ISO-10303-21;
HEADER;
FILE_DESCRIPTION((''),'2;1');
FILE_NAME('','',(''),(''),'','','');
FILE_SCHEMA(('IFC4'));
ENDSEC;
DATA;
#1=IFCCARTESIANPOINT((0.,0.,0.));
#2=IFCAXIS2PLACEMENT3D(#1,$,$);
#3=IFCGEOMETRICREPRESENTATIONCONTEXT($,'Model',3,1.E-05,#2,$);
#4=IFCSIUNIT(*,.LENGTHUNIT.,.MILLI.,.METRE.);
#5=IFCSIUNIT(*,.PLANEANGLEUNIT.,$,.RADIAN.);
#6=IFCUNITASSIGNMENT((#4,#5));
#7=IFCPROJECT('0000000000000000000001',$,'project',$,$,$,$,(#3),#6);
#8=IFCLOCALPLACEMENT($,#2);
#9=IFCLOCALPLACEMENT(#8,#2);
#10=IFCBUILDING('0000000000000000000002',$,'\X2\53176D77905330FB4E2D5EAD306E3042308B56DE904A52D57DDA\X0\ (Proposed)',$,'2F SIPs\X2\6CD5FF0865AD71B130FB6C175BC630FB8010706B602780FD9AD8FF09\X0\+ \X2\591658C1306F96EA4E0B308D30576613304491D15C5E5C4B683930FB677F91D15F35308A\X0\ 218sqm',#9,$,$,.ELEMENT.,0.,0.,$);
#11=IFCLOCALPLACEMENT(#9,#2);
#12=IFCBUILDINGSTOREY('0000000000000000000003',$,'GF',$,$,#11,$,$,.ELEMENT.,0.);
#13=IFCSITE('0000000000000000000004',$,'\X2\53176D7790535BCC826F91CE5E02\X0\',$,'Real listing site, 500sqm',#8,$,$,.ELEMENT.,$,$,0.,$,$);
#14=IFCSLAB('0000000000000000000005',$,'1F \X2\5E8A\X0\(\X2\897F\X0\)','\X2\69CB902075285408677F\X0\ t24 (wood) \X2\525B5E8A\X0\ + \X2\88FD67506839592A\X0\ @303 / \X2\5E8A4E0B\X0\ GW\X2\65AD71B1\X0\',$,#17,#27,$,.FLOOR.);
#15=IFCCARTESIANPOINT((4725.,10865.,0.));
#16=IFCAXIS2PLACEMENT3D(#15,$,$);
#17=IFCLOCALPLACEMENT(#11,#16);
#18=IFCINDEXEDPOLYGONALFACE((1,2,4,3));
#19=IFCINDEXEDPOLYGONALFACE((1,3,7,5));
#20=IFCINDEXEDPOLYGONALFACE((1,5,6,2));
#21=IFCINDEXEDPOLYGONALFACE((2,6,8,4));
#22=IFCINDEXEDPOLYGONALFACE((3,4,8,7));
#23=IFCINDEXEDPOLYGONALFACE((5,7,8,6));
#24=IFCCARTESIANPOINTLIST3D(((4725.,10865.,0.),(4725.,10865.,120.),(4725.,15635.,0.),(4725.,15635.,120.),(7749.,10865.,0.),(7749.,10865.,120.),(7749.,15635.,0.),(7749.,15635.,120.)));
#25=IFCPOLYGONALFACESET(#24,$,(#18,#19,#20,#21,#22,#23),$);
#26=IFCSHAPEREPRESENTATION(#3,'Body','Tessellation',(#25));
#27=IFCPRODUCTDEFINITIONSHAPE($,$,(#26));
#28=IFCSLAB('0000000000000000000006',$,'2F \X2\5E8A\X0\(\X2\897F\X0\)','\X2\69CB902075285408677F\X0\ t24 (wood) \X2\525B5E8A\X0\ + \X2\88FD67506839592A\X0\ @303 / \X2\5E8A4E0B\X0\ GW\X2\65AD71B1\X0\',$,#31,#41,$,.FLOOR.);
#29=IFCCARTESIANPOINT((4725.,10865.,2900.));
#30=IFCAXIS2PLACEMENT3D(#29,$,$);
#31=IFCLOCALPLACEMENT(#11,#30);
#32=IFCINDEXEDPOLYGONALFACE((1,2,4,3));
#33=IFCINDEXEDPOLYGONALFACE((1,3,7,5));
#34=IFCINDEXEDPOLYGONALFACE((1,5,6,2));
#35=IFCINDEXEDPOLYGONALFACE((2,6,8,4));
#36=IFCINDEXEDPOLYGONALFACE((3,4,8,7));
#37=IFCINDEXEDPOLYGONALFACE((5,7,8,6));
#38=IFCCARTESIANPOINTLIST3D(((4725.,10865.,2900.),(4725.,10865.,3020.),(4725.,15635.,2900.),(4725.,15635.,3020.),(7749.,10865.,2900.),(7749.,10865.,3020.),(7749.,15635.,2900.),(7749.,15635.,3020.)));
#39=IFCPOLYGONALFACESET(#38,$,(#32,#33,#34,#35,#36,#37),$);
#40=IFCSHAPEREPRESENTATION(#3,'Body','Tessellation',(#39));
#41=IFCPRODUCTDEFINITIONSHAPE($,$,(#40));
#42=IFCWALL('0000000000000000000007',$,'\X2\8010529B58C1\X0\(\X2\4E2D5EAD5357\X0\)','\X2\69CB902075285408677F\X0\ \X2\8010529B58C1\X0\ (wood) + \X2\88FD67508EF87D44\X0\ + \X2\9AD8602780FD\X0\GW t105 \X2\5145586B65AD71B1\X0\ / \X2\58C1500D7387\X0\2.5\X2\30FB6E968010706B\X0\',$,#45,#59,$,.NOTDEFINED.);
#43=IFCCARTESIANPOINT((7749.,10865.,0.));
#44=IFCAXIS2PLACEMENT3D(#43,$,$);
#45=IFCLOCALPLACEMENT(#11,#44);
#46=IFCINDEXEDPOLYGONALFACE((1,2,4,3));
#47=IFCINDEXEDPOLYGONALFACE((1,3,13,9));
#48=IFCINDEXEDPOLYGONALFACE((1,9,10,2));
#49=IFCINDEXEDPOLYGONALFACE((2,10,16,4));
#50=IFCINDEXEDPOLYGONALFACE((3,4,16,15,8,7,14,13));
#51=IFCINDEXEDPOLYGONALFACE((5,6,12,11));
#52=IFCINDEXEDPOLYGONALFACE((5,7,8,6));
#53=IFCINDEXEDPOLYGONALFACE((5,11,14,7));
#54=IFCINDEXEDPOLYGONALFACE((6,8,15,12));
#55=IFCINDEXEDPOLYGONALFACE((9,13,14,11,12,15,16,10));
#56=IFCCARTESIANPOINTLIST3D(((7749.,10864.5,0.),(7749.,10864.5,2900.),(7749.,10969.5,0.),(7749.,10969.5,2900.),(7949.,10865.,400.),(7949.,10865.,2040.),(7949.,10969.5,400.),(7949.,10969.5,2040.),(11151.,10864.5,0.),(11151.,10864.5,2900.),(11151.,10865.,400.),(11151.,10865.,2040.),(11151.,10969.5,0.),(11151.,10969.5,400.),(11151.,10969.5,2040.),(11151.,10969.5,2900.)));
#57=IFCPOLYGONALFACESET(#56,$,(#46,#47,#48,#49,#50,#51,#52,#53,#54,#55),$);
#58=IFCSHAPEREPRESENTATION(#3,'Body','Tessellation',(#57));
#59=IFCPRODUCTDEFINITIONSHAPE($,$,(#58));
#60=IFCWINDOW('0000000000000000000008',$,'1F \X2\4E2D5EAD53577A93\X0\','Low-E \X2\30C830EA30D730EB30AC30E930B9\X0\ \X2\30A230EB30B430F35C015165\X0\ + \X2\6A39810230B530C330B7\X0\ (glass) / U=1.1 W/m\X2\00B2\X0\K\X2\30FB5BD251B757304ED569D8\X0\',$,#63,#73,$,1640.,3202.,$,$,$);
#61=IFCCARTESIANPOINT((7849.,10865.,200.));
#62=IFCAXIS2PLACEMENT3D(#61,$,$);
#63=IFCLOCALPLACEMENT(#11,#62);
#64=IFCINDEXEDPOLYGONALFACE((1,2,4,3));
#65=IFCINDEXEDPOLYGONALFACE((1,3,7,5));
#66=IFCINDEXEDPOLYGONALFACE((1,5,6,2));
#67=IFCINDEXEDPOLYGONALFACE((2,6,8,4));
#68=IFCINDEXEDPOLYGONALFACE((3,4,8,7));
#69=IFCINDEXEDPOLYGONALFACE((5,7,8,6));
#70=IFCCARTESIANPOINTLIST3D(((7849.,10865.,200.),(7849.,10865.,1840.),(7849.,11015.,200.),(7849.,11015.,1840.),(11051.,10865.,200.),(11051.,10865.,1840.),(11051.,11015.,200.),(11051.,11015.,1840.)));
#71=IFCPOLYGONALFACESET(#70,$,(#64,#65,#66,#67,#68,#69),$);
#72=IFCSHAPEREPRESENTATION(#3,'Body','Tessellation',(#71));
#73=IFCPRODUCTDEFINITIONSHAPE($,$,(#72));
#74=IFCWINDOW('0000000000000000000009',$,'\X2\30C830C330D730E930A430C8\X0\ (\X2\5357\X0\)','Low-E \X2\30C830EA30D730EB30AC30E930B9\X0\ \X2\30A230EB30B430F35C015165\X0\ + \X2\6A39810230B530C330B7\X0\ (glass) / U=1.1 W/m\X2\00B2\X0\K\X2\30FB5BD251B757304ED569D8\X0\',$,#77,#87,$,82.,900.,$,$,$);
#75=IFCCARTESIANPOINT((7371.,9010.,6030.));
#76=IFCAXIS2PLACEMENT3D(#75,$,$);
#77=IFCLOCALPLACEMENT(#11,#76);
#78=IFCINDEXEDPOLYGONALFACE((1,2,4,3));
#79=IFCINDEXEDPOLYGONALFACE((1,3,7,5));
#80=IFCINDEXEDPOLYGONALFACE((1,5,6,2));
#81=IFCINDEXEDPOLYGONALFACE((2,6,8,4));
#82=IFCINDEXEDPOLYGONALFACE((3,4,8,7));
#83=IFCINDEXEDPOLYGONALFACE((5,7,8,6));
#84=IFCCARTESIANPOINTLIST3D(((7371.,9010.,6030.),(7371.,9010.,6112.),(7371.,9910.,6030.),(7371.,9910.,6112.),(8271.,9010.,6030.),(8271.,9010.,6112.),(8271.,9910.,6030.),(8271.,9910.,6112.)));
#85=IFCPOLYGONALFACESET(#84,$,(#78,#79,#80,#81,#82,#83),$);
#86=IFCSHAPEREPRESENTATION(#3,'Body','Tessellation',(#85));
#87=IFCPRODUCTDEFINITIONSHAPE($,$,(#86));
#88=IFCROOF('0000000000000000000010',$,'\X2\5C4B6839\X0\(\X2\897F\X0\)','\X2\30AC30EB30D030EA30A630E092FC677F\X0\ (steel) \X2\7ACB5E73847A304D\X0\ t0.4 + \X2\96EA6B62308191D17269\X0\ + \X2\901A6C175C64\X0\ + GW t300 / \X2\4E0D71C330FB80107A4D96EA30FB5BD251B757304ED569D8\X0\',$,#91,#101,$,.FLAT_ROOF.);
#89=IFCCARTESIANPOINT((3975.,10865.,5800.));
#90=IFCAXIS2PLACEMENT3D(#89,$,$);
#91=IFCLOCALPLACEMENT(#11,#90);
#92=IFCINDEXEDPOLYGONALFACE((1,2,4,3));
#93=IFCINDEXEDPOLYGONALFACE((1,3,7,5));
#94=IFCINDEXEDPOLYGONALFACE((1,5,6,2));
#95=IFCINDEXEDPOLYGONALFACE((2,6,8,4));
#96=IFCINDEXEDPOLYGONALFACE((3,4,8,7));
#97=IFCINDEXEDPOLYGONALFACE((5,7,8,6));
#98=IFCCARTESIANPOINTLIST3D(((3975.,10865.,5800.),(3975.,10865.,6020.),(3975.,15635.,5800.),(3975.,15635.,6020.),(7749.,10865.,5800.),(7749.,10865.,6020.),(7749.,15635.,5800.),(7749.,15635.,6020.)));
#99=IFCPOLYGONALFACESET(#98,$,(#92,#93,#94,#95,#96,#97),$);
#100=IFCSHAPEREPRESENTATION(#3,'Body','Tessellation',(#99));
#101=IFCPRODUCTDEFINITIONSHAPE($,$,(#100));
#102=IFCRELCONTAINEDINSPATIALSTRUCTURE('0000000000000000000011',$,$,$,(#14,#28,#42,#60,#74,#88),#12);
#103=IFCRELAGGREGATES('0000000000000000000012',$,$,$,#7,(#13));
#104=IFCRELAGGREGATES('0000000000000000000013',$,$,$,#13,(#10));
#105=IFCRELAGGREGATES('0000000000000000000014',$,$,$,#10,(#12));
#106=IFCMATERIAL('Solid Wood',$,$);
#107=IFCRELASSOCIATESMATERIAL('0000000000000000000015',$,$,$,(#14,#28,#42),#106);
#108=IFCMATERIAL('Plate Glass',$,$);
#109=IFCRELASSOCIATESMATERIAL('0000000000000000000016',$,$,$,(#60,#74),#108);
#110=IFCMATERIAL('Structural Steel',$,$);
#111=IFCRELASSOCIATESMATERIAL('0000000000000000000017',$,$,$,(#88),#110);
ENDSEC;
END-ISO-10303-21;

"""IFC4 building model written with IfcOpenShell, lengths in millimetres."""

from ifc_helpers import new_model, si_unit, frame, frame_2d, origin, place, context, project, spatial, rectangle, extrude, material, element, fill, save


model = new_model("IFC4")

# Units and contexts
model_context = context("Model", 3, precision=1e-05, world=origin())
ifc_project = project(units=[si_unit("LENGTHUNIT", "METRE", prefix="MILLI"), si_unit("PLANEANGLEUNIT", "RADIAN")], contexts=[model_context])

# Site, building, storey
site_placement = place(None, origin())
site = spatial("IfcSite", under=ifc_project, at=site_placement, Name="北海道富良野市", ObjectType="Real listing site, 500sqm", CompositionType="ELEMENT", RefElevation=0.0)
building_placement = place(site_placement, origin())
building = spatial("IfcBuilding", under=site, at=building_placement, Name="北海道・中庭のある回遊動線 (Proposed)", ObjectType="2F SIPs法（断熱・気密・耐火性能高）+ 外壁は雪下ろし易い金属屋根・板金張り 218sqm", CompositionType="ELEMENT", ElevationOfRefHeight=0.0, ElevationOfTerrain=0.0)
storey_placement = place(building_placement, origin())
storey = spatial("IfcBuildingStorey", under=building, at=storey_placement, Name="GF", CompositionType="ELEMENT", Elevation=0.0)

# Shared definitions
ifc_material_1 = material(Name="Solid Wood")

# Slabs
slab_1_placement = place(storey_placement, frame((4725.0, 10865.0, 0.0)))
element("IfcSlab", 1, at=slab_1_placement, inside=storey, material=ifc_material_1, Name="1F 床(西)", Description="構造用合板 t24 (wood) 剛床 + 製材根太 @303 / 床下 GW断熱", PredefinedType="FLOOR", context=model_context, shape_type="SweptSolid", body=[
    extrude(rectangle(XDim=3024.0, YDim=4770.0, at=frame_2d((1512.0, 2385.0))), frame((4725.0, 10865.0, 0.0)), (0.0, 0.0, 1.0), 120.0),
])
slab_2_placement = place(storey_placement, frame((4725.0, 10865.0, 2900.0)))
element("IfcSlab", 2, at=slab_2_placement, inside=storey, material=ifc_material_1, Name="2F 床(西)", Description="構造用合板 t24 (wood) 剛床 + 製材根太 @303 / 床下 GW断熱", PredefinedType="FLOOR", context=model_context, shape_type="SweptSolid", body=[
    extrude(rectangle(XDim=3024.0, YDim=4770.0, at=frame_2d((1512.0, 2385.0))), frame((4725.0, 10865.0, 2900.0)), (0.0, 0.0, 1.0), 120.0),
])

# Wall, opening, window
wall_placement = place(storey_placement, frame((7749.0, 10865.0, 0.0)))
wall = element("IfcWall", 3, at=wall_placement, inside=storey, material=ifc_material_1, Name="耐力壁(中庭南)", Description="構造用合板 耐力壁 (wood) + 製材軸組 + 高性能GW t105 充填断熱 / 壁倍率2.5・準耐火", PredefinedType="NOTDEFINED", context=model_context, shape_type="SweptSolid", body=[
    extrude(rectangle(XDim=3402.0, YDim=105.0, at=frame_2d((1701.0, 52.0))), frame((7749.0, 10865.0, 0.0)), (0.0, 0.0, 1.0), 2900.0),
])
opening_placement = place(storey_placement, frame((7849.0, 10865.0, 200.0)))
opening = element("IfcOpeningElement", 4, at=opening_placement, cuts=wall, PredefinedType="NOTDEFINED", context=model_context, shape_type="SweptSolid", body=[
    extrude(rectangle(XDim=3202.0, YDim=150.0, at=frame_2d((1601.0, 75.0))), frame((7849.0, 10865.0, 200.0)), (0.0, 0.0, 1.0), 1640.0),
])
ifc_material_2 = material(Name="Plate Glass")
window_1_placement = place(storey_placement, frame((7849.0, 10865.0, 200.0)))
window_1 = element("IfcWindow", 5, at=window_1_placement, inside=storey, material=ifc_material_2, Name="1F 中庭南窓", Description="Low-E トリプルガラス アルゴン封入 + 樹脂サッシ (glass) / U=1.1 W/m²K・寒冷地仕様", OverallHeight=1640.0, OverallWidth=3202.0, context=model_context, shape_type="SweptSolid", body=[
    extrude(rectangle(XDim=3202.0, YDim=150.0, at=frame_2d((1601.0, 75.0))), frame((7849.0, 10865.0, 200.0)), (0.0, 0.0, 1.0), 1640.0),
])
fill(opening, window_1)

# Window
window_2_placement = place(storey_placement, frame((7371.0, 9010.0, 6030.0)))
element("IfcWindow", 6, at=window_2_placement, inside=storey, material=ifc_material_2, Name="トップライト (南)", Description="Low-E トリプルガラス アルゴン封入 + 樹脂サッシ (glass) / U=1.1 W/m²K・寒冷地仕様", OverallHeight=82.0, OverallWidth=900.0, context=model_context, shape_type="SweptSolid", body=[
    extrude(rectangle(XDim=900.0, YDim=900.0, at=frame_2d((450.0, 450.0))), frame((7371.0, 9010.0, 6030.0)), (0.0, 0.0, 1.0), 82.0),
])

# Roof
ifc_material_3 = material(Name="Structural Steel")
for number, where, name in (
    (7, (3975.0, 10865.0, 5800.0), "屋根(西)"),
):
    element("IfcRoof", number, at=place(storey_placement, frame(where)), inside=storey, material=ifc_material_3, Name=name, Description="ガルバリウム鋼板 (steel) 立平葺き t0.4 + 雪止め金物 + 通気層 + GW t300 / 不燃・耐積雪・寒冷地仕様", PredefinedType="FLAT_ROOF", context=model_context, shape_type="SweptSolid", body=[
        extrude(rectangle(XDim=3774.0, YDim=4770.0, at=frame_2d((1887.0, 2385.0))), frame((3975.0, 10865.0, 5800.0)), (0.0, 0.0, 1.0), 220.0),
    ])

save(model, "model.ifc")
